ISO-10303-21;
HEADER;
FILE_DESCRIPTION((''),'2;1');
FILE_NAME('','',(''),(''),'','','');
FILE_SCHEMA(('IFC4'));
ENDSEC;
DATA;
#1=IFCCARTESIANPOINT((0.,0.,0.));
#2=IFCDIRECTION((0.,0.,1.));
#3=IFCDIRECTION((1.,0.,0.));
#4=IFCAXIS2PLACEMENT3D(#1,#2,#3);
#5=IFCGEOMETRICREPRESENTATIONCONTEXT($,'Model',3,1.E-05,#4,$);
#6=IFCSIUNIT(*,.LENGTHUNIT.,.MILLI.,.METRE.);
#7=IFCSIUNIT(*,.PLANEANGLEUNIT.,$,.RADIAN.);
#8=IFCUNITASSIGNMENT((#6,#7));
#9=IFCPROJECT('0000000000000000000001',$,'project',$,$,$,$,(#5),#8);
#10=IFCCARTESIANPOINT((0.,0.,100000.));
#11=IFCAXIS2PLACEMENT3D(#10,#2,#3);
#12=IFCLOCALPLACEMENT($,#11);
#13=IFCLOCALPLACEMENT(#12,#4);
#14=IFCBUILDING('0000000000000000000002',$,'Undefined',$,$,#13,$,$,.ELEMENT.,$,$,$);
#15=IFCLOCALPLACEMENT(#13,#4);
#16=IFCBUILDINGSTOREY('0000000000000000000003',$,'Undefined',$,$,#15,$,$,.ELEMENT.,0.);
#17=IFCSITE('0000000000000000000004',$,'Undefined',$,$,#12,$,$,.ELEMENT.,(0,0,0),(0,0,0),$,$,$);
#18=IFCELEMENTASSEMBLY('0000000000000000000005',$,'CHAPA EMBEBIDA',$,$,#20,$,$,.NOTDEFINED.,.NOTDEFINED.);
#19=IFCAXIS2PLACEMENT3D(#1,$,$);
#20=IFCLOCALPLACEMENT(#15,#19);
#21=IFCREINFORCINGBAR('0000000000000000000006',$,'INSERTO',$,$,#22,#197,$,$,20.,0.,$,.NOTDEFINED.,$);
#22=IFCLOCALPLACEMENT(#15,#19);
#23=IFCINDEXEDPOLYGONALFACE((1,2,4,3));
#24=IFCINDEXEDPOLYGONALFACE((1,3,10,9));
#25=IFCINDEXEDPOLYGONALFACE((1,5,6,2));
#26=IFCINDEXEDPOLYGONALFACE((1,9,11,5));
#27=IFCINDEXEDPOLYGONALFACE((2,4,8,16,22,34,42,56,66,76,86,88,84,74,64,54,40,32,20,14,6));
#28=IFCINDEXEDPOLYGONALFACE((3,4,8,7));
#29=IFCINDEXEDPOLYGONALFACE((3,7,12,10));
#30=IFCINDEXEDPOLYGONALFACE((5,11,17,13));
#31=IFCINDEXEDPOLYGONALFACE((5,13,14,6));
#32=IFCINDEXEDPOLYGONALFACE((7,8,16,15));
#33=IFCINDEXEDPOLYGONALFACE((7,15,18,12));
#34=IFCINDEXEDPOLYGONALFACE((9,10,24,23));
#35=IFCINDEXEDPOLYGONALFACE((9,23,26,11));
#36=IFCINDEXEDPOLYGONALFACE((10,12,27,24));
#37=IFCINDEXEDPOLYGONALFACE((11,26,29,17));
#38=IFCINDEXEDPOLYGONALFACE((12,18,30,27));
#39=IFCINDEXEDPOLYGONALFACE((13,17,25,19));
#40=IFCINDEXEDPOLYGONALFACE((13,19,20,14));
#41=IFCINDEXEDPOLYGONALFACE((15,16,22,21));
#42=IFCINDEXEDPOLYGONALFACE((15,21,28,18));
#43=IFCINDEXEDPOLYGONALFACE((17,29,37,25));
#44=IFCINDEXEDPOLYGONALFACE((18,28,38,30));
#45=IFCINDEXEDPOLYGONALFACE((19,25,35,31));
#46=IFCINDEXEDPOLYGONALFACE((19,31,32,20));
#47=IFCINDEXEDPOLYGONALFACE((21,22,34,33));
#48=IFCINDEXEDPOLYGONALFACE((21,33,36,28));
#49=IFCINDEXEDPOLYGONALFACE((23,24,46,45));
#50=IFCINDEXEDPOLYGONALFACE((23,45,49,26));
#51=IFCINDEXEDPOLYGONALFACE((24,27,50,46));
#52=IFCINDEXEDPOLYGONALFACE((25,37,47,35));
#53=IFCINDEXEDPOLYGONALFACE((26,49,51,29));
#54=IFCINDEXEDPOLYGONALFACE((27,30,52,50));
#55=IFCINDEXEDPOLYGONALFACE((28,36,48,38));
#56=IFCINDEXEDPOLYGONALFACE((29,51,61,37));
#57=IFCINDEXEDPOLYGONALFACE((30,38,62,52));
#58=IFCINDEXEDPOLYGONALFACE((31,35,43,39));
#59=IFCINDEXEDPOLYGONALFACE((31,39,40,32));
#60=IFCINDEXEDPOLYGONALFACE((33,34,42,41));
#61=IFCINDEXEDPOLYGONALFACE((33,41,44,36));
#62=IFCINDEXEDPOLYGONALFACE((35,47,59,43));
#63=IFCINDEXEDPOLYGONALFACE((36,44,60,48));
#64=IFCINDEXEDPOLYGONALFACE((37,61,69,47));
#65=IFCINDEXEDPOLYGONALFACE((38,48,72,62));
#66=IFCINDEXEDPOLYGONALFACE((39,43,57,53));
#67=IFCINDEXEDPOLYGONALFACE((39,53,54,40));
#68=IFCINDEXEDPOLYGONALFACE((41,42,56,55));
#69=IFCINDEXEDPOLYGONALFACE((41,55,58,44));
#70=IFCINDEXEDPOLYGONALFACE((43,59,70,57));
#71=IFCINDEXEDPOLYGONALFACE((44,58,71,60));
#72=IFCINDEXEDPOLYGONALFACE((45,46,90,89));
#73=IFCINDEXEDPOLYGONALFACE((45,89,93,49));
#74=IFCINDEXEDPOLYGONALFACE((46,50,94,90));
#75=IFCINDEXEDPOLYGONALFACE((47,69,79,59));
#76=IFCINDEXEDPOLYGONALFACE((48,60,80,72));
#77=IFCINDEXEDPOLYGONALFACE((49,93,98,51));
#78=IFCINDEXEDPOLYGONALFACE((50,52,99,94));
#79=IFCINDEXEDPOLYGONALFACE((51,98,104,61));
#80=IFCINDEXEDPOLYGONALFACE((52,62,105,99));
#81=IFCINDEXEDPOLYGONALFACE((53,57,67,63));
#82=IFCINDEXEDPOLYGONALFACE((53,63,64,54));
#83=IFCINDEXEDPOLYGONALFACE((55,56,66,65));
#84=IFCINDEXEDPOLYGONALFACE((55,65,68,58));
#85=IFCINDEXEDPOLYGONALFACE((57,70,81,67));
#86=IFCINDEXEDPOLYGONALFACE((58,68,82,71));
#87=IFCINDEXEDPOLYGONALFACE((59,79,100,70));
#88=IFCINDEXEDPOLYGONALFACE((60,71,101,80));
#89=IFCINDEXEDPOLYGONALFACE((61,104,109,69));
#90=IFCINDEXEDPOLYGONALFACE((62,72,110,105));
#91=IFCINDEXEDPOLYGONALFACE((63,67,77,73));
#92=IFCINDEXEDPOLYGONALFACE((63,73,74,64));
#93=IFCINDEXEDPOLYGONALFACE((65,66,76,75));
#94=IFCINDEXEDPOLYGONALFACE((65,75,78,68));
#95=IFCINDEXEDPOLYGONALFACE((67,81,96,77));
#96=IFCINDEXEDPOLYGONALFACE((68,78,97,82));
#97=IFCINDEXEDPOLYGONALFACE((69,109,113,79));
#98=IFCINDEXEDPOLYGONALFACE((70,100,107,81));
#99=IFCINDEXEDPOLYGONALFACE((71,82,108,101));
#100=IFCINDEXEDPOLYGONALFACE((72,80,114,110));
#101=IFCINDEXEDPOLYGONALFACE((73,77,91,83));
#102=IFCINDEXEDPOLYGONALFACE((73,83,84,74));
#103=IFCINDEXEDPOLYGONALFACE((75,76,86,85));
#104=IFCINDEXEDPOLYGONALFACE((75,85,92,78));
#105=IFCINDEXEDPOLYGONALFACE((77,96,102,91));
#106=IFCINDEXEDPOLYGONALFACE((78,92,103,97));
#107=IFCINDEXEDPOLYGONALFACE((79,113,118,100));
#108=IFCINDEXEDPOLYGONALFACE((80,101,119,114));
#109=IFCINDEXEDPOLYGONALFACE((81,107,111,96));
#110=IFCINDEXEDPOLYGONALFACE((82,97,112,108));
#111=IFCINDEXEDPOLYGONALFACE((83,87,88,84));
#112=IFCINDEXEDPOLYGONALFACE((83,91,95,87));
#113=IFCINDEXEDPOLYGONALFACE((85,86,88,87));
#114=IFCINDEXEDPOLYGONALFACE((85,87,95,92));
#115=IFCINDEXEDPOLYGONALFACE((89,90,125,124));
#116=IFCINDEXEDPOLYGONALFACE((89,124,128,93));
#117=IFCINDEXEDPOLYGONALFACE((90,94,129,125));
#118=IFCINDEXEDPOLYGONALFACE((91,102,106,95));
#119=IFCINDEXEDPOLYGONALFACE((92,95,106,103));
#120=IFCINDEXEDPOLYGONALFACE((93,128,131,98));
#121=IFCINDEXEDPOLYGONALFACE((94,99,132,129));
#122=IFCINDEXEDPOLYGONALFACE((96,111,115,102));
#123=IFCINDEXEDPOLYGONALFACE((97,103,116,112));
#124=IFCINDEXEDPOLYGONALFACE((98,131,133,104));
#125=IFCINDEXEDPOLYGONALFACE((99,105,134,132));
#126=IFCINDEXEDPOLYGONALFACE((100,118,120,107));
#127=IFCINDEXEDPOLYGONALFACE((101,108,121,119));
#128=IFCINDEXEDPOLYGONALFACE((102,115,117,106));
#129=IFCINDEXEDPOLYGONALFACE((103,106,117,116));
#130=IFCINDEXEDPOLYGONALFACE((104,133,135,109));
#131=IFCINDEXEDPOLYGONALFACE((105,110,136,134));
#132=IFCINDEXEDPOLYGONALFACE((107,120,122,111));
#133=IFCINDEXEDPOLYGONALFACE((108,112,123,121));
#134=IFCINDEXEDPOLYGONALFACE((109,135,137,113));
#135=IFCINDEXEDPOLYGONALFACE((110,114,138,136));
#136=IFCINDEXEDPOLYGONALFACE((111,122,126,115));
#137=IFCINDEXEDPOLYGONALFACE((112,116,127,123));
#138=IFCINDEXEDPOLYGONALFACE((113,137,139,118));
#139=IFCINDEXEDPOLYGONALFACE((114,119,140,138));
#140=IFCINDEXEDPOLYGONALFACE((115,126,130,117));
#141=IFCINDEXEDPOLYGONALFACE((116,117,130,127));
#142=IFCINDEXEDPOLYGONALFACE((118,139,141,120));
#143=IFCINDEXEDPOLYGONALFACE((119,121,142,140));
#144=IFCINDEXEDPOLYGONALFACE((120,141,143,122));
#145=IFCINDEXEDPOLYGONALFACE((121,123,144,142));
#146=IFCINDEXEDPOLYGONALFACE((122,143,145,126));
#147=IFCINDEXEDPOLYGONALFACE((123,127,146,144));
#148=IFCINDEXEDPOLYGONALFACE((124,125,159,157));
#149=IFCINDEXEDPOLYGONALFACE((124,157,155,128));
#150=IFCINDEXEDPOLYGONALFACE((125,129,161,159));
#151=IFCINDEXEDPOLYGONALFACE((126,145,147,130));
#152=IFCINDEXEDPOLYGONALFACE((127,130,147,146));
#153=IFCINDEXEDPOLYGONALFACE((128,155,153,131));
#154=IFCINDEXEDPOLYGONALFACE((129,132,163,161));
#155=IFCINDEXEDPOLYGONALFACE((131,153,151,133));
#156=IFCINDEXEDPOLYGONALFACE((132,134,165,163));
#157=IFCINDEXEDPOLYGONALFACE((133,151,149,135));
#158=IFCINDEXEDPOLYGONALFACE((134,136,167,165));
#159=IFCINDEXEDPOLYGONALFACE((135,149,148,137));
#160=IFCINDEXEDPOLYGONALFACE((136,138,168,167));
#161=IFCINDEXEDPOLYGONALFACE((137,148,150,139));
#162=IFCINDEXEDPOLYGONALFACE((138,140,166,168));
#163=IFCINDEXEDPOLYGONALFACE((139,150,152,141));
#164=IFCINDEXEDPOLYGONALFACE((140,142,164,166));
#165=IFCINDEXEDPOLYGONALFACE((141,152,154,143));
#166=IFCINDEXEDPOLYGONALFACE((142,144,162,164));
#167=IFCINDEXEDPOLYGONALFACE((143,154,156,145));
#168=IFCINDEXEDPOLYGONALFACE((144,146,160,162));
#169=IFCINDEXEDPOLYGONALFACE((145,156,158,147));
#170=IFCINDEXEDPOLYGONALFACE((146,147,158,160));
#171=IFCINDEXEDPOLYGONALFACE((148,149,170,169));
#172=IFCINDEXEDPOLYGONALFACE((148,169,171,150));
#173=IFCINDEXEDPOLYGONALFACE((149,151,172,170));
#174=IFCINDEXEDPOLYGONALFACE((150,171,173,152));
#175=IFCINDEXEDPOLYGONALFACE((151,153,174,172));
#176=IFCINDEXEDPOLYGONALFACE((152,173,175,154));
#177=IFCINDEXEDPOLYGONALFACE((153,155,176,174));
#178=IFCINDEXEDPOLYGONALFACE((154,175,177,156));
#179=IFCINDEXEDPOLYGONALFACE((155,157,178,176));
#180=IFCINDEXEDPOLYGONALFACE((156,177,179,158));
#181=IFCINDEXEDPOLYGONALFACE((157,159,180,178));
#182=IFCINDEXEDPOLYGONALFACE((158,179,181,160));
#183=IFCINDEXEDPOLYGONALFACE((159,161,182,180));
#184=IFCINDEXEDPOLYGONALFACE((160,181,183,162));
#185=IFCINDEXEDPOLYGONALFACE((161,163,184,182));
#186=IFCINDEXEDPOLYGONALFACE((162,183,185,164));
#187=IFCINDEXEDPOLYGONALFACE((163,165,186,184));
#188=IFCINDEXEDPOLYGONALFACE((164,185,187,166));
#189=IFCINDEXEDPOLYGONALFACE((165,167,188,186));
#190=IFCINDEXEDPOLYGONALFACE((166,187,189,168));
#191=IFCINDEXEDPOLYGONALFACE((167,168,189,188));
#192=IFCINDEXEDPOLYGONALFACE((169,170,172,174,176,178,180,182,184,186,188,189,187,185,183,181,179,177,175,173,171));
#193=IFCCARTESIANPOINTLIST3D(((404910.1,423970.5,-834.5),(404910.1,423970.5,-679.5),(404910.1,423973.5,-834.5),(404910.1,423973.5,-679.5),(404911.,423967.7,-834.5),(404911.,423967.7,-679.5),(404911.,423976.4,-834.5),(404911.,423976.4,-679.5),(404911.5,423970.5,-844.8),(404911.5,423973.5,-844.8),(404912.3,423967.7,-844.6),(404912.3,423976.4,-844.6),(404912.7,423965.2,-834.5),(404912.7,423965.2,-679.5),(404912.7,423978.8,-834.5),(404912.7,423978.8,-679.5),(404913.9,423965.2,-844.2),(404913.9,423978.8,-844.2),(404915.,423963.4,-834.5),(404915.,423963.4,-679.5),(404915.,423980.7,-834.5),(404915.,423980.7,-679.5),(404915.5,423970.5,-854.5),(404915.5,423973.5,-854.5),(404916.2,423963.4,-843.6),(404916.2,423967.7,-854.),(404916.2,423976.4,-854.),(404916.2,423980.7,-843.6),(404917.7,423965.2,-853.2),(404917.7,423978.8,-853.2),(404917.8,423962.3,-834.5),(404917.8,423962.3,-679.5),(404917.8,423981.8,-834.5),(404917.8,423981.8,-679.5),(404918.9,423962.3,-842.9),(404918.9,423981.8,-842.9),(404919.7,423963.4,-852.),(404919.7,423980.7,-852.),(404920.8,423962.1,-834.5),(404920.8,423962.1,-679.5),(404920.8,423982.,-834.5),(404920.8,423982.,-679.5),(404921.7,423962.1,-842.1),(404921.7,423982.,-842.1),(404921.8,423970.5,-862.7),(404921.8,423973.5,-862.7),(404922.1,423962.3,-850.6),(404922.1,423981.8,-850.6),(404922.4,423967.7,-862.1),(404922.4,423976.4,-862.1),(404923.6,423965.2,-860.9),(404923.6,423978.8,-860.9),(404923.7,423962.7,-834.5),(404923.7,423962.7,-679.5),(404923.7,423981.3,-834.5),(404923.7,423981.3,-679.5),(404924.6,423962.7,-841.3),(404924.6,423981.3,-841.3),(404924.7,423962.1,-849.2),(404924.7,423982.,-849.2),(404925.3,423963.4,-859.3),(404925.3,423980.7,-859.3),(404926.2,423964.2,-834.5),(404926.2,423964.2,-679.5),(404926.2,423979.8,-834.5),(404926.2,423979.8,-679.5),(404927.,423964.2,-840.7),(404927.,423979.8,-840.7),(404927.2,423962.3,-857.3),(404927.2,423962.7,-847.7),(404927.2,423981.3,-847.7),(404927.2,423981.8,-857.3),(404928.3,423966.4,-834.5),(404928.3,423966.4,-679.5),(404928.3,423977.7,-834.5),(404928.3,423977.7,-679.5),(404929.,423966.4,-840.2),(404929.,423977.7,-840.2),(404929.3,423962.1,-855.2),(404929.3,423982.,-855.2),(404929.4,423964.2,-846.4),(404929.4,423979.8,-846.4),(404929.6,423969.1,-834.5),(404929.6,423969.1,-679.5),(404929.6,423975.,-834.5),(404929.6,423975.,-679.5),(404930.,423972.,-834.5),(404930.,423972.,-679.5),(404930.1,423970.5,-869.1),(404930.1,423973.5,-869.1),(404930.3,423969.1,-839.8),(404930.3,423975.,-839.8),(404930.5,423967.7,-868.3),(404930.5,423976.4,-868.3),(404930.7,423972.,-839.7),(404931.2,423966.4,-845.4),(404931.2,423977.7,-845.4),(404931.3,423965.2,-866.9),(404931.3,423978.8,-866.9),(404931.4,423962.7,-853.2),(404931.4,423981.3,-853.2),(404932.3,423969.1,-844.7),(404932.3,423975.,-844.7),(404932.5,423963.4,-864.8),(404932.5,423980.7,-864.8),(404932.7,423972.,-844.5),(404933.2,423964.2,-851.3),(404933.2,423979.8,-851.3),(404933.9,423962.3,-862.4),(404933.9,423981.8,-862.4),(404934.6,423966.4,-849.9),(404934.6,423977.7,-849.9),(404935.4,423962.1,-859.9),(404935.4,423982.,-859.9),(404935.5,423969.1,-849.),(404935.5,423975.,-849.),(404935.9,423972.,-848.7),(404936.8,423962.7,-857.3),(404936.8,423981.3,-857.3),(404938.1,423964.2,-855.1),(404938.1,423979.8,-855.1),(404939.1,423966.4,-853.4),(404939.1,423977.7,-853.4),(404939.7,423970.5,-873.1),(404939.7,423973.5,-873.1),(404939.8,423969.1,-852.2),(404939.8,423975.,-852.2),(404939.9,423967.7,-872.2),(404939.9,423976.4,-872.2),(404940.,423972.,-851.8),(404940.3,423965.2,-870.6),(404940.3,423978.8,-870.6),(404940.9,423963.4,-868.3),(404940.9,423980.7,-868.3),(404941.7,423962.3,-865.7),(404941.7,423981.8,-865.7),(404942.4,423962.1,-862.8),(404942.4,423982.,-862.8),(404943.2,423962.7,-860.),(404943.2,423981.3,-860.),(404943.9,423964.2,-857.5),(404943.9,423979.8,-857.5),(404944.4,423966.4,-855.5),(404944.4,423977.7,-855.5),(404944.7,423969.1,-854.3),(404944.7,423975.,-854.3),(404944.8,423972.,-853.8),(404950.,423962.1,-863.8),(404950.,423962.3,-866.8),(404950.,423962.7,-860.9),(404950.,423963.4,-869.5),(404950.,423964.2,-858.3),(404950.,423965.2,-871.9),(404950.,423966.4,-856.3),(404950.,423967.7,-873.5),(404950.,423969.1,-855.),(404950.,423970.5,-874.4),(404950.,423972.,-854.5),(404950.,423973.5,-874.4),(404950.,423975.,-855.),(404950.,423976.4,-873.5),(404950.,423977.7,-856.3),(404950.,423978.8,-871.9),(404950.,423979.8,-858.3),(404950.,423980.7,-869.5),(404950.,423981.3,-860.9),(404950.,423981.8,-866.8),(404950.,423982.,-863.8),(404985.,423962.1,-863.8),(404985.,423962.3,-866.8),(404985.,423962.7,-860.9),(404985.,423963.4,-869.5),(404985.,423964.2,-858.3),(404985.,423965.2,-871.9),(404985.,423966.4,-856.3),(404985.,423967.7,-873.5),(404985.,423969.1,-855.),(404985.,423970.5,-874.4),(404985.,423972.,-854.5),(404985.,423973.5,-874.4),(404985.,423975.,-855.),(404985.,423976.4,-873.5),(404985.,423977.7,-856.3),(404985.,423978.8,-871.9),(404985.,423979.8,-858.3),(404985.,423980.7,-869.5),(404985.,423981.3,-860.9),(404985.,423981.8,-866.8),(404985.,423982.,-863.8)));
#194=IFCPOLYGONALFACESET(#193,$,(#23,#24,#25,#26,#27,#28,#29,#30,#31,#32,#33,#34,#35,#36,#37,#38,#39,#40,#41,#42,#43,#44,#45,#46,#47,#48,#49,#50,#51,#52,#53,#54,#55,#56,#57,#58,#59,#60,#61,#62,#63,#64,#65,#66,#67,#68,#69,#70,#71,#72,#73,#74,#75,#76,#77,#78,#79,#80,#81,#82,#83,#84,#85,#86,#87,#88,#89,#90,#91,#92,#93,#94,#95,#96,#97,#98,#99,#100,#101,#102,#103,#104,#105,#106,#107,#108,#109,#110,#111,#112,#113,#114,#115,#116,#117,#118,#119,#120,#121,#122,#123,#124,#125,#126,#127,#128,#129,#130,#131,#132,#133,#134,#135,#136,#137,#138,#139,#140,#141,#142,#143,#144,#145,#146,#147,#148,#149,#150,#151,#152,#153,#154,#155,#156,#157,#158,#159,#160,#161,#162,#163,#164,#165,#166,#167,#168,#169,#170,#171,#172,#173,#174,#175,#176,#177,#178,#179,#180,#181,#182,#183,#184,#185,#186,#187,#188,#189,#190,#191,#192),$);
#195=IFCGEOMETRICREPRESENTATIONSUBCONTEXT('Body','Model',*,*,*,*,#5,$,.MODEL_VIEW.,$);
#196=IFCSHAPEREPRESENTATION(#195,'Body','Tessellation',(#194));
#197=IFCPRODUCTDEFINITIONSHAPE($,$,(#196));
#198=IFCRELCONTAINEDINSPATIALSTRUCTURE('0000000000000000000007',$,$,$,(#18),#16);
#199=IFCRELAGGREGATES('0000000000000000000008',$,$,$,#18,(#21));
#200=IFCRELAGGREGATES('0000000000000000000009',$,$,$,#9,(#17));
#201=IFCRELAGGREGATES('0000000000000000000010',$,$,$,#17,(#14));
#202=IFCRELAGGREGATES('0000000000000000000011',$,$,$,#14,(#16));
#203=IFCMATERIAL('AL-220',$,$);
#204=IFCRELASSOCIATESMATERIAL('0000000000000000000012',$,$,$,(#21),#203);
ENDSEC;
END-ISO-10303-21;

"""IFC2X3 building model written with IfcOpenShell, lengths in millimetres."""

from ifc_helpers import new_model, entity, si_unit, frame, origin_with_axes, place, context, subcontext, project, spatial, source, transform, mapped, material, element, aggregate, save


model = new_model("IFC2X3")

# Units and contexts
model_context = context("Model", 3, precision=1e-05, world=origin_with_axes())
body_context = subcontext(model_context, "Body", "Model", "MODEL_VIEW")
ifc_project = project(units=[si_unit("LENGTHUNIT", "METRE", prefix="MILLI"), si_unit("PLANEANGLEUNIT", "RADIAN")], contexts=[model_context])

# Site, building, storey
site_placement = place(None, frame((0.0, 0.0, 100000.0), z_axis=(0.0, 0.0, 1.0), x_axis=(1.0, 0.0, 0.0)))
site = spatial("IfcSite", under=ifc_project, at=site_placement, Name="Undefined", CompositionType="ELEMENT", RefLatitude=(0, 0, 0), RefLongitude=(0, 0, 0))
building_placement = place(site_placement, origin_with_axes())
building = spatial("IfcBuilding", under=site, at=building_placement, Name="Undefined", CompositionType="ELEMENT")
storey_placement = place(building_placement, origin_with_axes())
storey = spatial("IfcBuildingStorey", under=building, at=storey_placement, Name="Undefined", CompositionType="ELEMENT", Elevation=0.0)

# Element assembly
assembly_1_placement = place(storey_placement, origin_with_axes())
assembly_1 = element("IfcElementAssembly", 1, at=assembly_1_placement, inside=storey, Name="CHAPA EMBEBIDA", AssemblyPlace="NOTDEFINED", PredefinedType="NOTDEFINED")

# Reinforcing bar
ifc_material_1 = material(Name="AL-220")
shared_shape_1 = source(origin_with_axes(), body_context, "Body", "AdvancedSweptSolid", [
    entity("IfcSweptDiskSolid", entity("IfcCompositeCurve", [entity("IfcCompositeCurveSegment", "CONTINUOUS", True, entity("IfcTrimmedCurve", entity("IfcLine", entity("IfcCartesianPoint", [0.0, 0.0, 0.0]), entity("IfcVector", entity("IfcDirection", [1.0, 0.0, 0.0]), 1.0)), [entity("IfcParameterValue", 0.0)], [entity("IfcParameterValue", 155.0)], True, "PARAMETER")), entity("IfcCompositeCurveSegment", "CONTINUOUS", True, entity("IfcTrimmedCurve", entity("IfcCircle", entity("IfcAxis2Placement3D", entity("IfcCartesianPoint", [155.0, 0.0, 30.0]), entity("IfcDirection", [0.0, -1.0, 0.0]), entity("IfcDirection", [0.0, 0.0, -1.0])), 30.0), [entity("IfcParameterValue", 0.0)], [entity("IfcParameterValue", 1.570796)], True, "PARAMETER")), entity("IfcCompositeCurveSegment", "DISCONTINUOUS", True, entity("IfcTrimmedCurve", entity("IfcLine", entity("IfcCartesianPoint", [185.0, 0.0, 30.0]), entity("IfcVector", entity("IfcDirection", [0.0, 0.0, 1.0]), 1.0)), [entity("IfcParameterValue", 0.0)], [entity("IfcParameterValue", 35.0)], True, "PARAMETER"))], False), 10.0, None, 0.0, 191.6),
])
reinforcing_bar_1_placement = place(assembly_1_placement, frame((404920.0, 423972.0, -679.5), z_axis=(1.0, 0.0, 0.0), x_axis=(0.0, 0.0, -1.0)))
reinforcing_bar_1 = element("IfcReinforcingBar", 2, at=reinforcing_bar_1_placement, material=ifc_material_1, Name="INSERTO", BarRole="NOTDEFINED", CrossSectionArea=0.0, NominalDiameter=20.0, context=body_context, shape_type="MappedRepresentation", body=[
    mapped(shared_shape_1, transform((0.0, 0.0, 0.0))),
])
aggregate(assembly_1, [reinforcing_bar_1])

save(model, "model.ifc")
